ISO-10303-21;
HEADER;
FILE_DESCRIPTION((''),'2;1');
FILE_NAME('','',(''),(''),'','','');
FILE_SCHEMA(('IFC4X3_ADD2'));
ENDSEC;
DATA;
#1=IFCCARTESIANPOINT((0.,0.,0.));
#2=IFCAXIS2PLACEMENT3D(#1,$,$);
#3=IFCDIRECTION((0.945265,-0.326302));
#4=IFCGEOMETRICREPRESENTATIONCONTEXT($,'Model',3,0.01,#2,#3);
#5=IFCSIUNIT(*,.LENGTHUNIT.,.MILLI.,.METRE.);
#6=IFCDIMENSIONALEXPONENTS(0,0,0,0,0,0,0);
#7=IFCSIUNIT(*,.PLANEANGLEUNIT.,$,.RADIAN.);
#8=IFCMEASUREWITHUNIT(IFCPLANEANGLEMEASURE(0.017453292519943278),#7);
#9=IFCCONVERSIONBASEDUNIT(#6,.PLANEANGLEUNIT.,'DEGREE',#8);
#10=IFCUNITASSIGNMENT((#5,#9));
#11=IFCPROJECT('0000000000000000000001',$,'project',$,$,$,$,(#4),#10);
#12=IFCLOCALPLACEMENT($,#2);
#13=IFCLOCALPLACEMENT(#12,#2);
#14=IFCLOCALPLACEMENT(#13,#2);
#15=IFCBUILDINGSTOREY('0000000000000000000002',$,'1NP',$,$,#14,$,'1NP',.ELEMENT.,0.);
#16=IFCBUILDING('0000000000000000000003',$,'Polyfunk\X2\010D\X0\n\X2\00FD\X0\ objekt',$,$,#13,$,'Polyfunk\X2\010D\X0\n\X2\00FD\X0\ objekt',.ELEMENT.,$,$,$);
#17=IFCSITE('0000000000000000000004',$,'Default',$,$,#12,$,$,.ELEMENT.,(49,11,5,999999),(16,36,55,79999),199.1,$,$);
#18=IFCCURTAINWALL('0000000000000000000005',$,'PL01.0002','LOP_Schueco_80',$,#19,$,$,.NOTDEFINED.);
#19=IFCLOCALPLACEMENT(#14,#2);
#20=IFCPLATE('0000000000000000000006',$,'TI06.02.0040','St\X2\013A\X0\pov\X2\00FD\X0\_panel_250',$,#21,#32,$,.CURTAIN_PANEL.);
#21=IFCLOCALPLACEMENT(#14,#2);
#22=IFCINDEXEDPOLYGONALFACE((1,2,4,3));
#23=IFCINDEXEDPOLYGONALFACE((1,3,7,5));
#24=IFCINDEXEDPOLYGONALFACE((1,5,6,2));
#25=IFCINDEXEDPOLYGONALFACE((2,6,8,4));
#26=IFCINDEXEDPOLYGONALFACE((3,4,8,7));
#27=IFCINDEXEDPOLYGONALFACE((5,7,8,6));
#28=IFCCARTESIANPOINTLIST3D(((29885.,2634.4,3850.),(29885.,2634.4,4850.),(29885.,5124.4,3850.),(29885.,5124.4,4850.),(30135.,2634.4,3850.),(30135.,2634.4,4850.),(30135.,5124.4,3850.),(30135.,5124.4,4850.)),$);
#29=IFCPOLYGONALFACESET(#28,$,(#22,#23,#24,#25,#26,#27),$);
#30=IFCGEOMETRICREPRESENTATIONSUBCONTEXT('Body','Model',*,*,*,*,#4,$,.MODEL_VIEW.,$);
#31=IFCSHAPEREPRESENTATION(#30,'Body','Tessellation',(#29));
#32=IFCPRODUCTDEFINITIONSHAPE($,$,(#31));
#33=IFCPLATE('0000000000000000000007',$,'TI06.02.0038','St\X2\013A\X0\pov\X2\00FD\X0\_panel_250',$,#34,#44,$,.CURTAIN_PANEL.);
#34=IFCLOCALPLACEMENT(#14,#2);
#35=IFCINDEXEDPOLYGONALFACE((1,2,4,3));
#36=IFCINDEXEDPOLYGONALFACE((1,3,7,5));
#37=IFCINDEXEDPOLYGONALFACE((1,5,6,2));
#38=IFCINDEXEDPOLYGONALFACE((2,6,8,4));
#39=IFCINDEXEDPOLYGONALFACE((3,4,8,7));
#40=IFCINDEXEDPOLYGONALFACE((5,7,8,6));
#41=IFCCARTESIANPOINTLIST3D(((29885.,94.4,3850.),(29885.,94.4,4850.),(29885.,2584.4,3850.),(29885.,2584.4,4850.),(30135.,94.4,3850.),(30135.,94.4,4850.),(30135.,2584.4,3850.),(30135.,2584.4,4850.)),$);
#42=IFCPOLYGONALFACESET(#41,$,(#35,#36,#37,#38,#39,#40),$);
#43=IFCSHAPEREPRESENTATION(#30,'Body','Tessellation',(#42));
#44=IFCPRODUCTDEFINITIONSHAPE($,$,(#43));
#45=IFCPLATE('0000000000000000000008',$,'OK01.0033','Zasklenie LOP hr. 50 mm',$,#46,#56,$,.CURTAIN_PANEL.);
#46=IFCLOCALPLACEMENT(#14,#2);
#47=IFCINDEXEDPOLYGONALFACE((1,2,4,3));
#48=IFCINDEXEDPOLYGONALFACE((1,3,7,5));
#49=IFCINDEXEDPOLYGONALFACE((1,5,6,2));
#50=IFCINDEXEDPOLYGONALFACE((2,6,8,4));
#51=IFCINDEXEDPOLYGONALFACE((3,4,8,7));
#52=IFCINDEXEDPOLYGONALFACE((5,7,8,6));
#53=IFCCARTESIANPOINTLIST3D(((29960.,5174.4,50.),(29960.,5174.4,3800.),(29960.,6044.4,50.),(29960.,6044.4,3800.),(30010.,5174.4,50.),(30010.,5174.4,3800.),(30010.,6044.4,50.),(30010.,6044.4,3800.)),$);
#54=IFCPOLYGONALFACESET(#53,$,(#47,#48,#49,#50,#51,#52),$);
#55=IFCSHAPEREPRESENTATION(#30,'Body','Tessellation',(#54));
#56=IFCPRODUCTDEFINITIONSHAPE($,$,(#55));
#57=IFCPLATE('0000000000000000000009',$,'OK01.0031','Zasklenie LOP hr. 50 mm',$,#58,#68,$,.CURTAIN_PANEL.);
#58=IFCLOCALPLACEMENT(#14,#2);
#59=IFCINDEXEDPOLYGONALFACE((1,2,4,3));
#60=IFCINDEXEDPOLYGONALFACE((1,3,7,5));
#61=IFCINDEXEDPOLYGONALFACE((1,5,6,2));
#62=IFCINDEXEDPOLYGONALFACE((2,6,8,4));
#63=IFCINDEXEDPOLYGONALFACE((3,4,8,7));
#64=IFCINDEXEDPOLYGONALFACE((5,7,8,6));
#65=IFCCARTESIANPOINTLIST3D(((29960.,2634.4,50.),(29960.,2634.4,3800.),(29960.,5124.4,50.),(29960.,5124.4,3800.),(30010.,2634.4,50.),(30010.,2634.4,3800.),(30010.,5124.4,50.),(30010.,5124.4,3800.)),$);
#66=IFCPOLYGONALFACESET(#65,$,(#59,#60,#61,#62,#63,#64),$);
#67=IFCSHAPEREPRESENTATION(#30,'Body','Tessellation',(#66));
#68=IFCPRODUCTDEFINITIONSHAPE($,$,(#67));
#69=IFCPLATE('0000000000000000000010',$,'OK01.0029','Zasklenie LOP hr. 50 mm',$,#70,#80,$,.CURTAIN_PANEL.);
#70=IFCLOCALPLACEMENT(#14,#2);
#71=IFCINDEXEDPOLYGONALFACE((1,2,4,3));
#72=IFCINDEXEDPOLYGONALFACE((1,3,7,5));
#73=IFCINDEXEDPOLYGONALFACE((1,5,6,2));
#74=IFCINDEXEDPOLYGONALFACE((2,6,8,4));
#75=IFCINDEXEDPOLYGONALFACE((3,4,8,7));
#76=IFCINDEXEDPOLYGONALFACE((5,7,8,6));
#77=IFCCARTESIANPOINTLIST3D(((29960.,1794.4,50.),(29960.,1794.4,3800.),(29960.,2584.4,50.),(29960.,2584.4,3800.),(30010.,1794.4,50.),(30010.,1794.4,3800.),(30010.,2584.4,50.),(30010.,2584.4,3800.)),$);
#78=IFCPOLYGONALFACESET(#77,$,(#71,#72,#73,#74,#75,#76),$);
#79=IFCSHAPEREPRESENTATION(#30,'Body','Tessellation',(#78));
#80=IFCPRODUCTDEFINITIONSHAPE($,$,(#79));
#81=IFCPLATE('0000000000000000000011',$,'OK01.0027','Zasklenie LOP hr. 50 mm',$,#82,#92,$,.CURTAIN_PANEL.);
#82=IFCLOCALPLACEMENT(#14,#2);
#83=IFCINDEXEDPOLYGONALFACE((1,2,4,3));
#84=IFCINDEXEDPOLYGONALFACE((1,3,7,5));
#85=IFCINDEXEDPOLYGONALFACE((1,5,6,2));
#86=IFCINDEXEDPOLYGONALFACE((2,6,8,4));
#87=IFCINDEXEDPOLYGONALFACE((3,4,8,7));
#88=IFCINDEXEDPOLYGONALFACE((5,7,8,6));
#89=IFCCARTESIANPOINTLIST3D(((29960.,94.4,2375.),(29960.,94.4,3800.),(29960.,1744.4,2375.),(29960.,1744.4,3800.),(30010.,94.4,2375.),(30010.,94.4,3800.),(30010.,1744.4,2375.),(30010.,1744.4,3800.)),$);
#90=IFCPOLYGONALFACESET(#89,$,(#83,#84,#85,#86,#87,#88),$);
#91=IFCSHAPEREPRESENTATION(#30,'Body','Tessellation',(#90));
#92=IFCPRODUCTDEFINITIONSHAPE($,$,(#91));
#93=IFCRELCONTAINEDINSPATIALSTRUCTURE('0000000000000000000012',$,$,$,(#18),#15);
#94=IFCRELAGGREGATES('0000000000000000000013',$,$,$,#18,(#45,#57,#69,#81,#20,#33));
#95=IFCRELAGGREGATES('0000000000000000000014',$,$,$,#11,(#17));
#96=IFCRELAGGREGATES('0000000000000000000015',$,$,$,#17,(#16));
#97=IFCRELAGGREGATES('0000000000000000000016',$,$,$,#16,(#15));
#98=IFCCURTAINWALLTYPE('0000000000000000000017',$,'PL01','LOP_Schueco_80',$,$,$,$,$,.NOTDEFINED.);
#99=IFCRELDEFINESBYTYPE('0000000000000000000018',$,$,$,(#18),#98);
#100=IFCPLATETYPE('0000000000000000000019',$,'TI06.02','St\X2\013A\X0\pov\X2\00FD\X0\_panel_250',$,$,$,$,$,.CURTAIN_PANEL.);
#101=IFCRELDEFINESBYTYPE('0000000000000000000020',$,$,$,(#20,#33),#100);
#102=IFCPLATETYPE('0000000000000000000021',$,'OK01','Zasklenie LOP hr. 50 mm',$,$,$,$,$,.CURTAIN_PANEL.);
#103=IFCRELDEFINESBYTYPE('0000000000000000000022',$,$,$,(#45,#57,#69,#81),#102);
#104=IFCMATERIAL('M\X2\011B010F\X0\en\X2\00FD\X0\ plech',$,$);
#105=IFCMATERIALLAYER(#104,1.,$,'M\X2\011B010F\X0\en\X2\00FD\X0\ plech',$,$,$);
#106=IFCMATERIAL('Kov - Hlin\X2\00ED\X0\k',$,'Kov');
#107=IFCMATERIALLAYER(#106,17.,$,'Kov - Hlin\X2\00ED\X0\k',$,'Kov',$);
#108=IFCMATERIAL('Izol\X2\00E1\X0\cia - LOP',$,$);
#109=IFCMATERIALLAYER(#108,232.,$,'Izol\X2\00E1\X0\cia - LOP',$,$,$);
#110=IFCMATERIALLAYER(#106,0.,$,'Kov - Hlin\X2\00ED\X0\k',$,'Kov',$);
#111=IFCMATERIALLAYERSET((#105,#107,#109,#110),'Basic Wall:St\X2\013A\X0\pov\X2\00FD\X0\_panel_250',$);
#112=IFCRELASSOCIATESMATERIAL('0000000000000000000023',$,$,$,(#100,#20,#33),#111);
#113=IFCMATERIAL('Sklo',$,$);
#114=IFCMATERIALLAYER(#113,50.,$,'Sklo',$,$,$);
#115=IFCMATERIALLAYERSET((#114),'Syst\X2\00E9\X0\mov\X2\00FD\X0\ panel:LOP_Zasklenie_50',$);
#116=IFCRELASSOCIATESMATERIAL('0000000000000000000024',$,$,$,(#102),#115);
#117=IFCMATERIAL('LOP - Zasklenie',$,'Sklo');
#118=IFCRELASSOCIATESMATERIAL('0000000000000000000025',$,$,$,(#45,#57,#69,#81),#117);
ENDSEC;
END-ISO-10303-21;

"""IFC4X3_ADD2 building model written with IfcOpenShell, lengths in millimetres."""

from ifc_helpers import new_model, entity, si_unit, converted_unit, direction, frame, frame_2d, origin, origin_2d_with_axis, place, context, subcontext, project, spatial, rectangle, extrude, source, transform, mapped, material, layer, layer_set, layer_usage, type_object, type_shapes, element, aggregate, save


model = new_model("IFC4X3_ADD2")

# Units and contexts
model_context = context("Model", 3, precision=0.01, world=origin(), true_north=direction((0.945265, -0.326302)))
body_context = subcontext(model_context, "Body", "Model", "MODEL_VIEW")
ifc_project = project(units=[si_unit("LENGTHUNIT", "METRE", prefix="MILLI"), converted_unit("PLANEANGLEUNIT", "DEGREE", entity("IfcPlaneAngleMeasure", 0.017453292519943278), si_unit("PLANEANGLEUNIT", "RADIAN"), dimensions=[0, 0, 0, 0, 0, 0, 0])], contexts=[model_context])

# Site, building, storey
site_placement = place(None, origin())
site = spatial("IfcSite", under=ifc_project, at=site_placement, Name="Default", CompositionType="ELEMENT", RefLatitude=(49, 11, 5, 999999), RefLongitude=(16, 36, 55, 79999), RefElevation=199.1)
building_placement = place(site_placement, origin())
building = spatial("IfcBuilding", under=site, at=building_placement, Name="Polyfunkčný objekt", LongName="Polyfunkčný objekt", CompositionType="ELEMENT")
storey_placement = place(building_placement, origin())
storey = spatial("IfcBuildingStorey", under=building, at=storey_placement, Name="1NP", LongName="1NP", CompositionType="ELEMENT", Elevation=0.0)

# Curtain wall, plates
curtain_wall_type = type_object("IfcCurtainWallType", Name="PL01", Description="LOP_Schueco_80", PredefinedType="NOTDEFINED")
curtain_wall_placement = place(storey_placement, origin())
curtain_wall = element("IfcCurtainWall", 1, at=curtain_wall_placement, inside=storey, type_object=curtain_wall_type, Name="PL01.0002", Description="LOP_Schueco_80", PredefinedType="NOTDEFINED")
ifc_material_1 = material(Name="Měďený plech")
ifc_layer_1 = layer(ifc_material_1, 1.0, Name="Měďený plech")
ifc_material_2 = material(Name="Kov - Hliník", Category="Kov")
ifc_layer_2 = layer(ifc_material_2, 17.0, Name="Kov - Hliník", Category="Kov")
ifc_material_3 = material(Name="Izolácia - LOP")
ifc_layer_3 = layer(ifc_material_3, 232.0, Name="Izolácia - LOP")
ifc_layer_4 = layer(ifc_material_2, 0.0, Name="Kov - Hliník", Category="Kov")
ifc_layer_set_1 = layer_set([ifc_layer_1, ifc_layer_2, ifc_layer_3, ifc_layer_4], Name="Basic Wall:Stĺpový_panel_250")
ifc_layer_usage_1 = layer_usage(ifc_layer_set_1, "AXIS2", "POSITIVE", -125.0)
plate_type_1 = type_object("IfcPlateType", Name="TI06.02", Description="Stĺpový_panel_250", PredefinedType="CURTAIN_PANEL", material=ifc_layer_set_1)
plate_1_placement = place(storey_placement, frame((30010.0, 5124.4, 3850.0), z_axis=(0.0, 0.0, 1.0), x_axis=(0.0, -1.0, 0.0)))
plate_1 = element("IfcPlate", 2, at=plate_1_placement, type_object=plate_type_1, material=ifc_layer_usage_1, Name="TI06.02.0040", Description="Stĺpový_panel_250", PredefinedType="CURTAIN_PANEL", context=body_context, shape_type="SweptSolid", body=[
    extrude(rectangle(XDim=250.0, YDim=2490.0, at=frame_2d((0.0, 0.0), x_axis=(1.0, 0.0))), frame((1245.0, 0.0, 0.0), z_axis=(0.0, 0.0, 1.0), x_axis=(0.0, 1.0, 0.0)), (0.0, 0.0, 1.0), 1000.0),
])
ifc_layer_usage_2 = layer_usage(ifc_layer_set_1, "AXIS2", "POSITIVE", -125.0)
plate_2_placement = place(storey_placement, frame((30010.0, 2584.4, 3850.0), z_axis=(0.0, 0.0, 1.0), x_axis=(0.0, -1.0, 0.0)))
plate_2 = element("IfcPlate", 3, at=plate_2_placement, type_object=plate_type_1, material=ifc_layer_usage_2, Name="TI06.02.0038", Description="Stĺpový_panel_250", PredefinedType="CURTAIN_PANEL", context=body_context, shape_type="SweptSolid", body=[
    extrude(rectangle(XDim=250.0, YDim=2490.0, at=frame_2d((0.0, 0.0), x_axis=(1.0, 0.0))), frame((1245.0, 0.0, 0.0), z_axis=(0.0, 0.0, 1.0), x_axis=(0.0, 1.0, 0.0)), (0.0, 0.0, 1.0), 1000.0),
])
ifc_material_4 = material(Name="LOP - Zasklenie", Category="Sklo")
ifc_material_5 = material(Name="Sklo")
ifc_layer_5 = layer(ifc_material_5, 50.0, Name="Sklo")
ifc_layer_set_2 = layer_set([ifc_layer_5], Name="Systémový panel:LOP_Zasklenie_50")
plate_type_2 = type_object("IfcPlateType", Name="OK01", Description="Zasklenie LOP hr. 50 mm", PredefinedType="CURTAIN_PANEL", material=ifc_layer_set_2)
shared_shape_1 = source(origin(), body_context, "Body", "SweptSolid", [
    extrude(rectangle(XDim=3750.0, YDim=870.0, at=frame_2d((-141.7, 0.0), x_axis=(1.0, 0.0))), frame((0.0, -50.0, 2016.7), z_axis=(0.0, 1.0, 0.0), x_axis=(0.0, 0.0, 1.0)), (0.0, 0.0, 1.0), 50.0),
])
plate_3_placement = place(curtain_wall_placement, frame((30010.0, 5609.4, 50.0), z_axis=(0.0, 0.0, 1.0), x_axis=(0.0, -1.0, 0.0)))
plate_3 = element("IfcPlate", 4, at=plate_3_placement, type_object=plate_type_2, material=ifc_material_4, Name="OK01.0033", Description="Zasklenie LOP hr. 50 mm", PredefinedType="CURTAIN_PANEL", context=body_context, shape_type="MappedRepresentation", body=[
    mapped(shared_shape_1, transform((0.0, 0.0, 0.0), scale=1.0)),
])
shared_shape_2 = source(origin(), body_context, "Body", "SweptSolid", [
    extrude(rectangle(XDim=3750.0, YDim=2490.0, at=frame_2d((-141.7, 0.0), x_axis=(1.0, 0.0))), frame((0.0, -50.0, 2016.7), z_axis=(0.0, 1.0, 0.0), x_axis=(0.0, 0.0, 1.0)), (0.0, 0.0, 1.0), 50.0),
])
plate_4_placement = place(curtain_wall_placement, frame((30010.0, 3879.4, 50.0), z_axis=(0.0, 0.0, 1.0), x_axis=(0.0, -1.0, 0.0)))
plate_4 = element("IfcPlate", 5, at=plate_4_placement, type_object=plate_type_2, material=ifc_material_4, Name="OK01.0031", Description="Zasklenie LOP hr. 50 mm", PredefinedType="CURTAIN_PANEL", context=body_context, shape_type="MappedRepresentation", body=[
    mapped(shared_shape_2, transform((0.0, 0.0, 0.0), scale=1.0)),
])
shared_shape_3 = source(origin(), body_context, "Body", "SweptSolid", [
    extrude(rectangle(XDim=3750.0, YDim=790.0, at=frame_2d((-141.7, 0.0), x_axis=(1.0, 0.0))), frame((0.0, -50.0, 2016.7), z_axis=(0.0, 1.0, 0.0), x_axis=(0.0, 0.0, 1.0)), (0.0, 0.0, 1.0), 50.0),
])
plate_5_placement = place(curtain_wall_placement, frame((30010.0, 2189.4, 50.0), z_axis=(0.0, 0.0, 1.0), x_axis=(0.0, -1.0, 0.0)))
plate_5 = element("IfcPlate", 6, at=plate_5_placement, type_object=plate_type_2, material=ifc_material_4, Name="OK01.0029", Description="Zasklenie LOP hr. 50 mm", PredefinedType="CURTAIN_PANEL", context=body_context, shape_type="MappedRepresentation", body=[
    mapped(shared_shape_3, transform((0.0, 0.0, 0.0), scale=1.0)),
])
shared_shape_4 = source(origin(), body_context, "Body", "SweptSolid", [
    extrude(rectangle(XDim=50.0, YDim=1650.0, at=origin_2d_with_axis()), frame((0.0, -25.0, 0.0), z_axis=(0.0, 0.0, 1.0), x_axis=(0.0, 1.0, 0.0)), (0.0, 0.0, 1.0), 1425.0),
])
type_shapes(plate_type_2, [shared_shape_1, shared_shape_2, shared_shape_3, shared_shape_4])
plate_6_placement = place(curtain_wall_placement, frame((30010.0, 919.4, 2375.0), z_axis=(0.0, 0.0, 1.0), x_axis=(0.0, -1.0, 0.0)))
plate_6 = element("IfcPlate", 7, at=plate_6_placement, type_object=plate_type_2, material=ifc_material_4, Name="OK01.0027", Description="Zasklenie LOP hr. 50 mm", PredefinedType="CURTAIN_PANEL", context=body_context, shape_type="MappedRepresentation", body=[
    mapped(shared_shape_4, transform((0.0, 0.0, 0.0), scale=1.0)),
])
aggregate(curtain_wall, [plate_3, plate_4, plate_5, plate_6, plate_1, plate_2])

save(model, "model.ifc")
